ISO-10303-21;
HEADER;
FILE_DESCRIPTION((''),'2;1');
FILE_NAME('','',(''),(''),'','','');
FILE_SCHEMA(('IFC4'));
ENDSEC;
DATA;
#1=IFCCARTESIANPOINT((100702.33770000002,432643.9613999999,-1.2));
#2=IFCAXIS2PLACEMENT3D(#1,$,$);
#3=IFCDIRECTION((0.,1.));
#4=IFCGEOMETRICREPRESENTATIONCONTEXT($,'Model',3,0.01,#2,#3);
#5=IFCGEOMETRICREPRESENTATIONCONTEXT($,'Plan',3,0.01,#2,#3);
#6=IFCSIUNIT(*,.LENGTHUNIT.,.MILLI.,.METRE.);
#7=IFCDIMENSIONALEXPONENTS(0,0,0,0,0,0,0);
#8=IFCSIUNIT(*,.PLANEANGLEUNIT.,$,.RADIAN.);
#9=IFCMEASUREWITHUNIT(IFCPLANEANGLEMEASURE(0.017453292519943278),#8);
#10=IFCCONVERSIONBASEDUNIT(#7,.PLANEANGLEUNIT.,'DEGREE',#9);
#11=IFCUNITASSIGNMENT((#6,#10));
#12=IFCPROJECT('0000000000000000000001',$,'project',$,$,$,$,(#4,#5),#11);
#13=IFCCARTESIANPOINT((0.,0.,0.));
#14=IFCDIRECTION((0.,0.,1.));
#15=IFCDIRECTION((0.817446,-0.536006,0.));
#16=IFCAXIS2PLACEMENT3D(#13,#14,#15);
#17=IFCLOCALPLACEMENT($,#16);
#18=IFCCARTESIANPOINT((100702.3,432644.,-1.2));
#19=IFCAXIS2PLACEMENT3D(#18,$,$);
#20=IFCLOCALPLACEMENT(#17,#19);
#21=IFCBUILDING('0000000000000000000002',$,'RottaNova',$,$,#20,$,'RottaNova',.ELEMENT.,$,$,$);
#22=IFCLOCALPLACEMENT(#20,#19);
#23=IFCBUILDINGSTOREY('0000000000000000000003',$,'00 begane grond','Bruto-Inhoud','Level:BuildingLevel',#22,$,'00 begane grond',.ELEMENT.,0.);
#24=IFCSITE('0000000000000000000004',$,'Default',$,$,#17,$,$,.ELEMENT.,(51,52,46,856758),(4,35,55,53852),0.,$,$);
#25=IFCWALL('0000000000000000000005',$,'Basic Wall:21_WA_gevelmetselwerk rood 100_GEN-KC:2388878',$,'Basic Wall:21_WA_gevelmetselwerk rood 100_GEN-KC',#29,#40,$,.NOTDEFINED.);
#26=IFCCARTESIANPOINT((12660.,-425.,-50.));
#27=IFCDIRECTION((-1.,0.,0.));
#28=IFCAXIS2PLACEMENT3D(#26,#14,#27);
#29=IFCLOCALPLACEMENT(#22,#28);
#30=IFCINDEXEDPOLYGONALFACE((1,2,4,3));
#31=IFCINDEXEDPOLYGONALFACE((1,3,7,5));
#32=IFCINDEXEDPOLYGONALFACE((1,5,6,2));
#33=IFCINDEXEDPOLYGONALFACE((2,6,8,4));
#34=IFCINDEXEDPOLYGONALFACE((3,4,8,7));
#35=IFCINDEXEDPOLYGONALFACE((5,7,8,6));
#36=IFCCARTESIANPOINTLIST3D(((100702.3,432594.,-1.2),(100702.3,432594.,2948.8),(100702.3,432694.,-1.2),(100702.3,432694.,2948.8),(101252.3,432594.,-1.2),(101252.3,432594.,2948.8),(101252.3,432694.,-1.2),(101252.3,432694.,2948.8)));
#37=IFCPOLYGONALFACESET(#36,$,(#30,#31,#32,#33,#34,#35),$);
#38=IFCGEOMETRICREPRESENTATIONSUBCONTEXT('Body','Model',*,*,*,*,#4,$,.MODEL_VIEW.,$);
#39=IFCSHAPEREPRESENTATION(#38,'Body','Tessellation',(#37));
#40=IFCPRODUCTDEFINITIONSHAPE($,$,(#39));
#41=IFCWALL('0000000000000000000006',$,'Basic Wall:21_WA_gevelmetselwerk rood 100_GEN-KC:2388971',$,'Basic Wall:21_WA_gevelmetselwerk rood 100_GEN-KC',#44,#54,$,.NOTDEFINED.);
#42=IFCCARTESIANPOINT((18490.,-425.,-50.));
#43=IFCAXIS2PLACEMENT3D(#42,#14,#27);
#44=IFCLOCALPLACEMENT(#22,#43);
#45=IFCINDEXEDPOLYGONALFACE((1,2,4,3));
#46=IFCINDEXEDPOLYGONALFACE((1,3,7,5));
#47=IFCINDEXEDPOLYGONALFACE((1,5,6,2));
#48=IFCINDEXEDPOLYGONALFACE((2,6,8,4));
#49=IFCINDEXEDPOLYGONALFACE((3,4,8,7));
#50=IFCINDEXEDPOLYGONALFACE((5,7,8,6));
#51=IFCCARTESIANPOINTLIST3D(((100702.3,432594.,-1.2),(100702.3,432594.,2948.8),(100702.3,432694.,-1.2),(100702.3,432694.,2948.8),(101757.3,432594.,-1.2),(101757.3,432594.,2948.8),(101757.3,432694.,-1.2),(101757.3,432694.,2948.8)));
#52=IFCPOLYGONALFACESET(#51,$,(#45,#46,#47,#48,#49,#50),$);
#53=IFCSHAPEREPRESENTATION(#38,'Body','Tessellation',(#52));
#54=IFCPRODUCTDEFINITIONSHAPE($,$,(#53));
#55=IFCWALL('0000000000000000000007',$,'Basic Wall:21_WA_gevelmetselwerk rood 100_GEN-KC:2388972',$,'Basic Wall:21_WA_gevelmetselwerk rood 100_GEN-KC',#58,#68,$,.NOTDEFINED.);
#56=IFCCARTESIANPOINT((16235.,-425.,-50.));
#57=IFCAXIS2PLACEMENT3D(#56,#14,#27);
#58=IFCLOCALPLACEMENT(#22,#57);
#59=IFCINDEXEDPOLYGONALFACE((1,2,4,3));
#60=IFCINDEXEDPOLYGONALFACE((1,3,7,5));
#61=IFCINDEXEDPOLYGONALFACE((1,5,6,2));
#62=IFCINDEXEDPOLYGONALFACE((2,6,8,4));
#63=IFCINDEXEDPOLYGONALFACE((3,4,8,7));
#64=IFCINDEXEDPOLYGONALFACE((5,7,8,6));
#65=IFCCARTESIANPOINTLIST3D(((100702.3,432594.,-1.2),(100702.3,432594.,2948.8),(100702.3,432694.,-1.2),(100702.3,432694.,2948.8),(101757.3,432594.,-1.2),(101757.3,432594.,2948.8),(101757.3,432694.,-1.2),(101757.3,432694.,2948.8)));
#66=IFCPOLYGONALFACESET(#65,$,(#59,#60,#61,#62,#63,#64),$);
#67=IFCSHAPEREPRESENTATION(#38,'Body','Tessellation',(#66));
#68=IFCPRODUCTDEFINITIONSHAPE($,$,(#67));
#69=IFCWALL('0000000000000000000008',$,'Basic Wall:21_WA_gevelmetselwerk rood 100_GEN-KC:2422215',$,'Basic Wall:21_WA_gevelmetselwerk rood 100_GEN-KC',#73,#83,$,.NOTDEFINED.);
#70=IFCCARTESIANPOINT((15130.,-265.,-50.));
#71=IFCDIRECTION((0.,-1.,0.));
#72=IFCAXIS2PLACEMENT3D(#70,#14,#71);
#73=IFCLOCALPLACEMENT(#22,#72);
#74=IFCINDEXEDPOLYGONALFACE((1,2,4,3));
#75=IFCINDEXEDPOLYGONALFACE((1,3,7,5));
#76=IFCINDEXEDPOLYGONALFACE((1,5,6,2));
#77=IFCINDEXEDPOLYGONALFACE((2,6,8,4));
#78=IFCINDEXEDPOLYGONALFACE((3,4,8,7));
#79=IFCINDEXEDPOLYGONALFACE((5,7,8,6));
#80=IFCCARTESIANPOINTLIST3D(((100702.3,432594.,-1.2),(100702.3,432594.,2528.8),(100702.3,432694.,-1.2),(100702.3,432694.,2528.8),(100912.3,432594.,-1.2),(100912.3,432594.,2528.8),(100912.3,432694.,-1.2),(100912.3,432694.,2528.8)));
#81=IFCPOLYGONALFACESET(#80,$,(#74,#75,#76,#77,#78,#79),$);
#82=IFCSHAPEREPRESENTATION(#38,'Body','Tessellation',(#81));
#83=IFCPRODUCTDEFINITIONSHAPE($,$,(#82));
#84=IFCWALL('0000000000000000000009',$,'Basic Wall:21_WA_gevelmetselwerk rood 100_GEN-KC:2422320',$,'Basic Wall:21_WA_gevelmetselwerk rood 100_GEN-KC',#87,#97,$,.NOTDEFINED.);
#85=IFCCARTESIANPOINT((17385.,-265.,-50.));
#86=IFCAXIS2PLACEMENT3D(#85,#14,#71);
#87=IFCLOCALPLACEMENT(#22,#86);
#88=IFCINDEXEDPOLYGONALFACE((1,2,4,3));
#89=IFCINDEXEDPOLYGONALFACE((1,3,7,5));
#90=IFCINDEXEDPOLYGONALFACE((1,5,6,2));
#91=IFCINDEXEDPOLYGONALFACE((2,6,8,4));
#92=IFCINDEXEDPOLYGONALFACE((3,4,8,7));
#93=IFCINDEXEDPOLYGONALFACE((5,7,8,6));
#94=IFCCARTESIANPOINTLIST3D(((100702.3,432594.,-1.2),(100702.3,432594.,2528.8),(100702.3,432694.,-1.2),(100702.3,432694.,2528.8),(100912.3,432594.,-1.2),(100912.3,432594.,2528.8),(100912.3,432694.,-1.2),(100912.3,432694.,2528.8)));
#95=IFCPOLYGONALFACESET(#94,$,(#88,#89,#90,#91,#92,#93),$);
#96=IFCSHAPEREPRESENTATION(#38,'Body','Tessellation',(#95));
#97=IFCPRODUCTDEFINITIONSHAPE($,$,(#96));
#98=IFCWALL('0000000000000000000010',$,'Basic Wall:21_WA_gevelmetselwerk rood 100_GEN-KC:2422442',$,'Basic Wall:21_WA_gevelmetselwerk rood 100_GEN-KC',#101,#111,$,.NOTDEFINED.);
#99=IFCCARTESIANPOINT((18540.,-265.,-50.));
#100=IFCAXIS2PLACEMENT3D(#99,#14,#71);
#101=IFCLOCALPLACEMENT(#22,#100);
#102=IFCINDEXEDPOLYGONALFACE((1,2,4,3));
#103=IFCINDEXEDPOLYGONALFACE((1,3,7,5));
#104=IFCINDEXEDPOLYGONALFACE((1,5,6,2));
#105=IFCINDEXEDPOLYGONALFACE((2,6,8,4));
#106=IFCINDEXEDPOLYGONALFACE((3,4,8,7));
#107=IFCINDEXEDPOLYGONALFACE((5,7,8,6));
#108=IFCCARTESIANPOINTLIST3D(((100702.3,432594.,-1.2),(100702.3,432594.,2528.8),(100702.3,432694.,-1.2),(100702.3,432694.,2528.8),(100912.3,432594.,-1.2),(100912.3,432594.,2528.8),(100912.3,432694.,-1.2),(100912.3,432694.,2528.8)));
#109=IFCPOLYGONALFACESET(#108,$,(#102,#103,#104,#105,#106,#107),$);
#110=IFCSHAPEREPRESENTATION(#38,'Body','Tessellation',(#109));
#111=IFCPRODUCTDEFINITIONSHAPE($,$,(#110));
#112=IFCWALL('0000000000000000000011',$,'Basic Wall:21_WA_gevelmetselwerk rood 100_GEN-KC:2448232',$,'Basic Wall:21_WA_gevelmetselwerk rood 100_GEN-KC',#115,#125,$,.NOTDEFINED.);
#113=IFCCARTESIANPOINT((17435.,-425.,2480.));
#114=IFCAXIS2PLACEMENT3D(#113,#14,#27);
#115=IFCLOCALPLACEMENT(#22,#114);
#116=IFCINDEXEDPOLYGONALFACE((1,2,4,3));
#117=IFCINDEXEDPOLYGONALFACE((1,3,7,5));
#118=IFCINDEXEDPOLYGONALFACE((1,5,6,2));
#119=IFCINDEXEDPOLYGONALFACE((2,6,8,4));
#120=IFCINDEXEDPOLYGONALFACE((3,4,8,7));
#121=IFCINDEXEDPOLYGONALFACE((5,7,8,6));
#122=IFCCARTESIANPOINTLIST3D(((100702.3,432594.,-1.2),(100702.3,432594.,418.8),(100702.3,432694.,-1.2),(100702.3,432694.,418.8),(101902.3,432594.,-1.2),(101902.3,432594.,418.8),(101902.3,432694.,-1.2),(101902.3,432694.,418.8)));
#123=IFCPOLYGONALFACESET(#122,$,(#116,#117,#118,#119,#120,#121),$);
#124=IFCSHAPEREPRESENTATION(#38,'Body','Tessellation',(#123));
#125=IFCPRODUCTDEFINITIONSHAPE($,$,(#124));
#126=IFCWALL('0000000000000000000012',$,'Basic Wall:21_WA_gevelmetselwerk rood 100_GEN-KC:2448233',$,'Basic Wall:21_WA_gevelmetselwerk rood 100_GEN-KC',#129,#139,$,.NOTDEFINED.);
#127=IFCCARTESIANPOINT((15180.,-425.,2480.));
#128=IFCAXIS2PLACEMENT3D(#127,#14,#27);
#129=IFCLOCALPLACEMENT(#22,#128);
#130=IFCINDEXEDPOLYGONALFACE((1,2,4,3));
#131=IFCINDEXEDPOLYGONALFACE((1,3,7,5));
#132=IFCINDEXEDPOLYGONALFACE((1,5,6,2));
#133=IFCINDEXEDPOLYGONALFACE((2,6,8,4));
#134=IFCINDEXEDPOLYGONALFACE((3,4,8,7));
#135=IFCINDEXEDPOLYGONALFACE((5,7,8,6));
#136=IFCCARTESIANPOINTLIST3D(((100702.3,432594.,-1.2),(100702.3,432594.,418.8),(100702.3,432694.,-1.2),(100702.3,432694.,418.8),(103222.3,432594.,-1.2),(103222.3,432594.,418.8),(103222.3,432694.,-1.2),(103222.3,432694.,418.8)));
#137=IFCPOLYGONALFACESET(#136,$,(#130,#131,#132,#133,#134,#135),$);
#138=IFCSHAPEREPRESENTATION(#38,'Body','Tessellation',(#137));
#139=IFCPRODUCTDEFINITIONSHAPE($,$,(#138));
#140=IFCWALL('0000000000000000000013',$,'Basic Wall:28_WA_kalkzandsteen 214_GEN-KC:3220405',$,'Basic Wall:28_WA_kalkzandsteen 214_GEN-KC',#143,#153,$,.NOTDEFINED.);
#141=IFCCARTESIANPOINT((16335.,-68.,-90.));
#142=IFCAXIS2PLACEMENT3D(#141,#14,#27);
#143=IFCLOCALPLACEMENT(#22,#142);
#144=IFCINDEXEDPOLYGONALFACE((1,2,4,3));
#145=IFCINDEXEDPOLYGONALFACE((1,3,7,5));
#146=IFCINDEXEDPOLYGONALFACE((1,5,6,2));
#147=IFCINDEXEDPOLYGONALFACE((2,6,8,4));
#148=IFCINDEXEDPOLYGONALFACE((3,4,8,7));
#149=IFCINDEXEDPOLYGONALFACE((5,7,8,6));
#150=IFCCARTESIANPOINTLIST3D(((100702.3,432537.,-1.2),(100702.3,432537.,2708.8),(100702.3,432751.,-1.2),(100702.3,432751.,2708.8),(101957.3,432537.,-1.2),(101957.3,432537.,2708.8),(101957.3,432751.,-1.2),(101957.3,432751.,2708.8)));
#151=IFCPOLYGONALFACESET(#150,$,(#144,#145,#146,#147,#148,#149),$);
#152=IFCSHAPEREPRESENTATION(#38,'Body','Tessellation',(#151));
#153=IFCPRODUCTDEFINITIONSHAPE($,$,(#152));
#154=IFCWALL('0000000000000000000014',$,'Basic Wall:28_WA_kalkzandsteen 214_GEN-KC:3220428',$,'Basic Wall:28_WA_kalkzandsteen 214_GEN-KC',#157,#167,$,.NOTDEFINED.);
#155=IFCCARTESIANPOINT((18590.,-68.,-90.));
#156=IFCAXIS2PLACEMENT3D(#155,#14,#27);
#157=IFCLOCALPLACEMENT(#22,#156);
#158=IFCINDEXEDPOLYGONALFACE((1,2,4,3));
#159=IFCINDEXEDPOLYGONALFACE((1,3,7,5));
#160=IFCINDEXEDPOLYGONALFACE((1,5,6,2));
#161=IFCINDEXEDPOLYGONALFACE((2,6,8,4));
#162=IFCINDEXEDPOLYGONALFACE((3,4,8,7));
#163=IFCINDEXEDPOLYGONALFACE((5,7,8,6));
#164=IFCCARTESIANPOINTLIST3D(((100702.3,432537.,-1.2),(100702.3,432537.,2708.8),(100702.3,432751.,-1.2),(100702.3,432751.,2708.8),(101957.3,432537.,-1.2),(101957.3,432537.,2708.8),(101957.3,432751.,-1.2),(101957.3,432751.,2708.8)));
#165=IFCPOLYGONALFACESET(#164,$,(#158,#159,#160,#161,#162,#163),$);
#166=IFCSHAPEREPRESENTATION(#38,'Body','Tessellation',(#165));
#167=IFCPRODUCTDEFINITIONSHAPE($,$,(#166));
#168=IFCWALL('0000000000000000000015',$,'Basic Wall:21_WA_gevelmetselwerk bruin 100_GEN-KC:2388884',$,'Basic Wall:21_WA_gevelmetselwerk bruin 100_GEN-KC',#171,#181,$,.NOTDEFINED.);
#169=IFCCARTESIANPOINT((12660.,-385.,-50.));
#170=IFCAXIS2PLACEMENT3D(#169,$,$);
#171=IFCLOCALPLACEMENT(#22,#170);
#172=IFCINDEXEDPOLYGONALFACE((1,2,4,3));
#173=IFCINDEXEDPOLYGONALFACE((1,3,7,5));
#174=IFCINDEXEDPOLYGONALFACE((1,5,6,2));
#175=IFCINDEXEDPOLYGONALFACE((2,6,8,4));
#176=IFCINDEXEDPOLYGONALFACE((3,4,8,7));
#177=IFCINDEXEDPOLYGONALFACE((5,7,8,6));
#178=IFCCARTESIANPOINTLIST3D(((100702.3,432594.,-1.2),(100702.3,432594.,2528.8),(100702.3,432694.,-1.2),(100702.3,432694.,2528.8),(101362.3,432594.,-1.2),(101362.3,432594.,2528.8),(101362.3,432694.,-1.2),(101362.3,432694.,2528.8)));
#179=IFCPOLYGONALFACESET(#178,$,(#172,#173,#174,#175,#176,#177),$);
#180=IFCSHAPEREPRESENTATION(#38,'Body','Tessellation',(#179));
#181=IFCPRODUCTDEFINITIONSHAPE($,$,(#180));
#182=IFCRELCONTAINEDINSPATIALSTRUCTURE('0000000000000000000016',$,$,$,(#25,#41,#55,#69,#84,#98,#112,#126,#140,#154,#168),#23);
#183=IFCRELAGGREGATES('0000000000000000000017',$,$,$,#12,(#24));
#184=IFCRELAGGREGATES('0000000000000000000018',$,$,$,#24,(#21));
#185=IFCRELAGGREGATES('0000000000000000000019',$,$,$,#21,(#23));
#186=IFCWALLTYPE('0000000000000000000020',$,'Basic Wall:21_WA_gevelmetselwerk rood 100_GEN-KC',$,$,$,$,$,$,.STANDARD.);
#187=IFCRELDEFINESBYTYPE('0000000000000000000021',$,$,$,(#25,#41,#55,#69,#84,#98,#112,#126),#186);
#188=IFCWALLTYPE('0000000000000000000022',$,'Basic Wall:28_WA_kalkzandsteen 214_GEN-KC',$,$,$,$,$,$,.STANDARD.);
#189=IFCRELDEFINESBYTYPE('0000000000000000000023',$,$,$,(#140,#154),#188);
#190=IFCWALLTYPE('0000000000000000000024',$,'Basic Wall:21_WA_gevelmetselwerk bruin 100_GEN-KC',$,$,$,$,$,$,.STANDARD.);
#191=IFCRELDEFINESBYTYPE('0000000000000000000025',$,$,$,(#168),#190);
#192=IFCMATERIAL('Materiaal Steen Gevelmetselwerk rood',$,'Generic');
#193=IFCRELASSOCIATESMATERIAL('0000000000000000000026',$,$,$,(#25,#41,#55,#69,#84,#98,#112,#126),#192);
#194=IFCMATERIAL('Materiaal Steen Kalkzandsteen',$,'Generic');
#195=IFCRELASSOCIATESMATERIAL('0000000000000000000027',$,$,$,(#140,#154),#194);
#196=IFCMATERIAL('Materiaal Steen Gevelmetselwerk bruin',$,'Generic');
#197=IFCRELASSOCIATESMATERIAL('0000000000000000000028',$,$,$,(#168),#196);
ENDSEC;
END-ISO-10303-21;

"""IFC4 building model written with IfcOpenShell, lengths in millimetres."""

from ifc_helpers import new_model, entity, si_unit, converted_unit, direction, frame, place, context, subcontext, project, spatial, indexed_curve, outline, extrude, material, type_object, element, save


model = new_model("IFC4")

# Units and contexts
model_context = context("Model", 3, precision=0.01, world=frame((100702.33770000002, 432643.9613999999, -1.2)), true_north=direction((0.0, 1.0)))
plan_context = context("Plan", 3, precision=0.01, world=frame((100702.33770000002, 432643.9613999999, -1.2)), true_north=direction((0.0, 1.0)))
body_context = subcontext(model_context, "Body", "Model", "MODEL_VIEW")
ifc_project = project(units=[si_unit("LENGTHUNIT", "METRE", prefix="MILLI"), converted_unit("PLANEANGLEUNIT", "DEGREE", entity("IfcPlaneAngleMeasure", 0.017453292519943278), si_unit("PLANEANGLEUNIT", "RADIAN"), dimensions=[0, 0, 0, 0, 0, 0, 0])], contexts=[model_context, plan_context])

# Site, building, storey
site_placement = place(None, frame((0.0, 0.0, 0.0), z_axis=(0.0, 0.0, 1.0), x_axis=(0.817446, -0.536006, 0.0)))
site = spatial("IfcSite", under=ifc_project, at=site_placement, Name="Default", CompositionType="ELEMENT", RefLatitude=(51, 52, 46, 856758), RefLongitude=(4, 35, 55, 53852), RefElevation=0.0)
building_placement = place(site_placement, frame((100702.3, 432644.0, -1.2)))
building = spatial("IfcBuilding", under=site, at=building_placement, Name="RottaNova", LongName="RottaNova", CompositionType="ELEMENT")
storey_placement = place(building_placement, frame((100702.3, 432644.0, -1.2)))
storey = spatial("IfcBuildingStorey", under=building, at=storey_placement, Name="00 begane grond", Description="Bruto-Inhoud", ObjectType="Level:BuildingLevel", LongName="00 begane grond", CompositionType="ELEMENT", Elevation=0.0)

# Walls
ifc_material_1 = material(Name="Materiaal Steen Gevelmetselwerk rood", Category="Generic")
wall_type_1 = type_object("IfcWallType", Name="Basic Wall:21_WA_gevelmetselwerk rood 100_GEN-KC", PredefinedType="STANDARD")
wall_1_placement = place(storey_placement, frame((12660.0, -425.0, -50.0), z_axis=(0.0, 0.0, 1.0), x_axis=(-1.0, 0.0, 0.0)))
element("IfcWall", 1, at=wall_1_placement, inside=storey, type_object=wall_type_1, material=ifc_material_1, Name="Basic Wall:21_WA_gevelmetselwerk rood 100_GEN-KC:2388878", ObjectType="Basic Wall:21_WA_gevelmetselwerk rood 100_GEN-KC", PredefinedType="NOTDEFINED", context=body_context, shape_type="SweptSolid", body=[
    extrude(outline(indexed_curve([(550.0, 50.0), (0.0, 50.0), (0.0, -50.0), (550.0, -50.0), (550.0, 50.0)], self_intersect=False)), frame((100702.3, 432644.0, -1.2)), (0.0, 0.0, 1.0), 2950.0),
])
wall_2_placement = place(storey_placement, frame((18490.0, -425.0, -50.0), z_axis=(0.0, 0.0, 1.0), x_axis=(-1.0, 0.0, 0.0)))
element("IfcWall", 2, at=wall_2_placement, inside=storey, type_object=wall_type_1, material=ifc_material_1, Name="Basic Wall:21_WA_gevelmetselwerk rood 100_GEN-KC:2388971", ObjectType="Basic Wall:21_WA_gevelmetselwerk rood 100_GEN-KC", PredefinedType="NOTDEFINED", context=body_context, shape_type="SweptSolid", body=[
    extrude(outline(indexed_curve([(1055.0, 50.0), (0.0, 50.0), (0.0, -50.0), (1055.0, -50.0), (1055.0, 50.0)], self_intersect=False)), frame((100702.3, 432644.0, -1.2)), (0.0, 0.0, 1.0), 2950.0),
])
wall_3_placement = place(storey_placement, frame((16235.0, -425.0, -50.0), z_axis=(0.0, 0.0, 1.0), x_axis=(-1.0, 0.0, 0.0)))
element("IfcWall", 3, at=wall_3_placement, inside=storey, type_object=wall_type_1, material=ifc_material_1, Name="Basic Wall:21_WA_gevelmetselwerk rood 100_GEN-KC:2388972", ObjectType="Basic Wall:21_WA_gevelmetselwerk rood 100_GEN-KC", PredefinedType="NOTDEFINED", context=body_context, shape_type="SweptSolid", body=[
    extrude(outline(indexed_curve([(1055.0, 50.0), (0.0, 50.0), (0.0, -50.0), (1055.0, -50.0), (1055.0, 50.0)], self_intersect=False)), frame((100702.3, 432644.0, -1.2)), (0.0, 0.0, 1.0), 2950.0),
])
wall_4_placement = place(storey_placement, frame((15130.0, -265.0, -50.0), z_axis=(0.0, 0.0, 1.0), x_axis=(0.0, -1.0, 0.0)))
element("IfcWall", 4, at=wall_4_placement, inside=storey, type_object=wall_type_1, material=ifc_material_1, Name="Basic Wall:21_WA_gevelmetselwerk rood 100_GEN-KC:2422215", ObjectType="Basic Wall:21_WA_gevelmetselwerk rood 100_GEN-KC", PredefinedType="NOTDEFINED", context=body_context, shape_type="SweptSolid", body=[
    extrude(outline(indexed_curve([(210.0, 50.0), (0.0, 50.0), (0.0, -50.0), (210.0, -50.0), (210.0, 50.0)], self_intersect=False)), frame((100702.3, 432644.0, -1.2)), (0.0, 0.0, 1.0), 2530.0),
])
wall_5_placement = place(storey_placement, frame((17385.0, -265.0, -50.0), z_axis=(0.0, 0.0, 1.0), x_axis=(0.0, -1.0, 0.0)))
element("IfcWall", 5, at=wall_5_placement, inside=storey, type_object=wall_type_1, material=ifc_material_1, Name="Basic Wall:21_WA_gevelmetselwerk rood 100_GEN-KC:2422320", ObjectType="Basic Wall:21_WA_gevelmetselwerk rood 100_GEN-KC", PredefinedType="NOTDEFINED", context=body_context, shape_type="SweptSolid", body=[
    extrude(outline(indexed_curve([(210.0, 50.0), (0.0, 50.0), (0.0, -50.0), (210.0, -50.0), (210.0, 50.0)], self_intersect=False)), frame((100702.3, 432644.0, -1.2)), (0.0, 0.0, 1.0), 2530.0),
])
wall_6_placement = place(storey_placement, frame((18540.0, -265.0, -50.0), z_axis=(0.0, 0.0, 1.0), x_axis=(0.0, -1.0, 0.0)))
element("IfcWall", 6, at=wall_6_placement, inside=storey, type_object=wall_type_1, material=ifc_material_1, Name="Basic Wall:21_WA_gevelmetselwerk rood 100_GEN-KC:2422442", ObjectType="Basic Wall:21_WA_gevelmetselwerk rood 100_GEN-KC", PredefinedType="NOTDEFINED", context=body_context, shape_type="SweptSolid", body=[
    extrude(outline(indexed_curve([(210.0, 50.0), (0.0, 50.0), (0.0, -50.0), (210.0, -50.0), (210.0, 50.0)], self_intersect=False)), frame((100702.3, 432644.0, -1.2)), (0.0, 0.0, 1.0), 2530.0),
])
wall_7_placement = place(storey_placement, frame((17435.0, -425.0, 2480.0), z_axis=(0.0, 0.0, 1.0), x_axis=(-1.0, 0.0, 0.0)))
element("IfcWall", 7, at=wall_7_placement, inside=storey, type_object=wall_type_1, material=ifc_material_1, Name="Basic Wall:21_WA_gevelmetselwerk rood 100_GEN-KC:2448232", ObjectType="Basic Wall:21_WA_gevelmetselwerk rood 100_GEN-KC", PredefinedType="NOTDEFINED", context=body_context, shape_type="SweptSolid", body=[
    extrude(outline(indexed_curve([(1200.0, 50.0), (0.0, 50.0), (0.0, -50.0), (1200.0, -50.0), (1200.0, 50.0)], self_intersect=False)), frame((100702.3, 432644.0, -1.2)), (0.0, 0.0, 1.0), 420.0),
])
wall_8_placement = place(storey_placement, frame((15180.0, -425.0, 2480.0), z_axis=(0.0, 0.0, 1.0), x_axis=(-1.0, 0.0, 0.0)))
element("IfcWall", 8, at=wall_8_placement, inside=storey, type_object=wall_type_1, material=ifc_material_1, Name="Basic Wall:21_WA_gevelmetselwerk rood 100_GEN-KC:2448233", ObjectType="Basic Wall:21_WA_gevelmetselwerk rood 100_GEN-KC", PredefinedType="NOTDEFINED", context=body_context, shape_type="SweptSolid", body=[
    extrude(outline(indexed_curve([(2520.0, 50.0), (0.0, 50.0), (0.0, -50.0), (2520.0, -50.0), (2520.0, 50.0)], self_intersect=False)), frame((100702.3, 432644.0, -1.2)), (0.0, 0.0, 1.0), 420.0),
])
ifc_material_2 = material(Name="Materiaal Steen Kalkzandsteen", Category="Generic")
wall_type_2 = type_object("IfcWallType", Name="Basic Wall:28_WA_kalkzandsteen 214_GEN-KC", PredefinedType="STANDARD")
wall_9_placement = place(storey_placement, frame((16335.0, -68.0, -90.0), z_axis=(0.0, 0.0, 1.0), x_axis=(-1.0, 0.0, 0.0)))
element("IfcWall", 9, at=wall_9_placement, inside=storey, type_object=wall_type_2, material=ifc_material_2, Name="Basic Wall:28_WA_kalkzandsteen 214_GEN-KC:3220405", ObjectType="Basic Wall:28_WA_kalkzandsteen 214_GEN-KC", PredefinedType="NOTDEFINED", context=body_context, shape_type="SweptSolid", body=[
    extrude(outline(indexed_curve([(1255.0, 107.0), (0.0, 107.0), (0.0, -107.0), (1255.0, -107.0), (1255.0, 107.0)], self_intersect=False)), frame((100702.3, 432644.0, -1.2)), (0.0, 0.0, 1.0), 2710.0),
])
wall_10_placement = place(storey_placement, frame((18590.0, -68.0, -90.0), z_axis=(0.0, 0.0, 1.0), x_axis=(-1.0, 0.0, 0.0)))
element("IfcWall", 10, at=wall_10_placement, inside=storey, type_object=wall_type_2, material=ifc_material_2, Name="Basic Wall:28_WA_kalkzandsteen 214_GEN-KC:3220428", ObjectType="Basic Wall:28_WA_kalkzandsteen 214_GEN-KC", PredefinedType="NOTDEFINED", context=body_context, shape_type="SweptSolid", body=[
    extrude(outline(indexed_curve([(1255.0, 107.0), (0.0, 107.0), (0.0, -107.0), (1255.0, -107.0), (1255.0, 107.0)], self_intersect=False)), frame((100702.3, 432644.0, -1.2)), (0.0, 0.0, 1.0), 2710.0),
])
ifc_material_3 = material(Name="Materiaal Steen Gevelmetselwerk bruin", Category="Generic")
wall_type_3 = type_object("IfcWallType", Name="Basic Wall:21_WA_gevelmetselwerk bruin 100_GEN-KC", PredefinedType="STANDARD")
wall_11_placement = place(storey_placement, frame((12660.0, -385.0, -50.0)))
element("IfcWall", 11, at=wall_11_placement, inside=storey, type_object=wall_type_3, material=ifc_material_3, Name="Basic Wall:21_WA_gevelmetselwerk bruin 100_GEN-KC:2388884", ObjectType="Basic Wall:21_WA_gevelmetselwerk bruin 100_GEN-KC", PredefinedType="NOTDEFINED", context=body_context, shape_type="SweptSolid", body=[
    extrude(outline(indexed_curve([(660.0, 50.0), (0.0, 50.0), (0.0, -50.0), (660.0, -50.0), (660.0, 50.0)], self_intersect=False)), frame((100702.3, 432644.0, -1.2)), (0.0, 0.0, 1.0), 2530.0),
])

save(model, "model.ifc")
